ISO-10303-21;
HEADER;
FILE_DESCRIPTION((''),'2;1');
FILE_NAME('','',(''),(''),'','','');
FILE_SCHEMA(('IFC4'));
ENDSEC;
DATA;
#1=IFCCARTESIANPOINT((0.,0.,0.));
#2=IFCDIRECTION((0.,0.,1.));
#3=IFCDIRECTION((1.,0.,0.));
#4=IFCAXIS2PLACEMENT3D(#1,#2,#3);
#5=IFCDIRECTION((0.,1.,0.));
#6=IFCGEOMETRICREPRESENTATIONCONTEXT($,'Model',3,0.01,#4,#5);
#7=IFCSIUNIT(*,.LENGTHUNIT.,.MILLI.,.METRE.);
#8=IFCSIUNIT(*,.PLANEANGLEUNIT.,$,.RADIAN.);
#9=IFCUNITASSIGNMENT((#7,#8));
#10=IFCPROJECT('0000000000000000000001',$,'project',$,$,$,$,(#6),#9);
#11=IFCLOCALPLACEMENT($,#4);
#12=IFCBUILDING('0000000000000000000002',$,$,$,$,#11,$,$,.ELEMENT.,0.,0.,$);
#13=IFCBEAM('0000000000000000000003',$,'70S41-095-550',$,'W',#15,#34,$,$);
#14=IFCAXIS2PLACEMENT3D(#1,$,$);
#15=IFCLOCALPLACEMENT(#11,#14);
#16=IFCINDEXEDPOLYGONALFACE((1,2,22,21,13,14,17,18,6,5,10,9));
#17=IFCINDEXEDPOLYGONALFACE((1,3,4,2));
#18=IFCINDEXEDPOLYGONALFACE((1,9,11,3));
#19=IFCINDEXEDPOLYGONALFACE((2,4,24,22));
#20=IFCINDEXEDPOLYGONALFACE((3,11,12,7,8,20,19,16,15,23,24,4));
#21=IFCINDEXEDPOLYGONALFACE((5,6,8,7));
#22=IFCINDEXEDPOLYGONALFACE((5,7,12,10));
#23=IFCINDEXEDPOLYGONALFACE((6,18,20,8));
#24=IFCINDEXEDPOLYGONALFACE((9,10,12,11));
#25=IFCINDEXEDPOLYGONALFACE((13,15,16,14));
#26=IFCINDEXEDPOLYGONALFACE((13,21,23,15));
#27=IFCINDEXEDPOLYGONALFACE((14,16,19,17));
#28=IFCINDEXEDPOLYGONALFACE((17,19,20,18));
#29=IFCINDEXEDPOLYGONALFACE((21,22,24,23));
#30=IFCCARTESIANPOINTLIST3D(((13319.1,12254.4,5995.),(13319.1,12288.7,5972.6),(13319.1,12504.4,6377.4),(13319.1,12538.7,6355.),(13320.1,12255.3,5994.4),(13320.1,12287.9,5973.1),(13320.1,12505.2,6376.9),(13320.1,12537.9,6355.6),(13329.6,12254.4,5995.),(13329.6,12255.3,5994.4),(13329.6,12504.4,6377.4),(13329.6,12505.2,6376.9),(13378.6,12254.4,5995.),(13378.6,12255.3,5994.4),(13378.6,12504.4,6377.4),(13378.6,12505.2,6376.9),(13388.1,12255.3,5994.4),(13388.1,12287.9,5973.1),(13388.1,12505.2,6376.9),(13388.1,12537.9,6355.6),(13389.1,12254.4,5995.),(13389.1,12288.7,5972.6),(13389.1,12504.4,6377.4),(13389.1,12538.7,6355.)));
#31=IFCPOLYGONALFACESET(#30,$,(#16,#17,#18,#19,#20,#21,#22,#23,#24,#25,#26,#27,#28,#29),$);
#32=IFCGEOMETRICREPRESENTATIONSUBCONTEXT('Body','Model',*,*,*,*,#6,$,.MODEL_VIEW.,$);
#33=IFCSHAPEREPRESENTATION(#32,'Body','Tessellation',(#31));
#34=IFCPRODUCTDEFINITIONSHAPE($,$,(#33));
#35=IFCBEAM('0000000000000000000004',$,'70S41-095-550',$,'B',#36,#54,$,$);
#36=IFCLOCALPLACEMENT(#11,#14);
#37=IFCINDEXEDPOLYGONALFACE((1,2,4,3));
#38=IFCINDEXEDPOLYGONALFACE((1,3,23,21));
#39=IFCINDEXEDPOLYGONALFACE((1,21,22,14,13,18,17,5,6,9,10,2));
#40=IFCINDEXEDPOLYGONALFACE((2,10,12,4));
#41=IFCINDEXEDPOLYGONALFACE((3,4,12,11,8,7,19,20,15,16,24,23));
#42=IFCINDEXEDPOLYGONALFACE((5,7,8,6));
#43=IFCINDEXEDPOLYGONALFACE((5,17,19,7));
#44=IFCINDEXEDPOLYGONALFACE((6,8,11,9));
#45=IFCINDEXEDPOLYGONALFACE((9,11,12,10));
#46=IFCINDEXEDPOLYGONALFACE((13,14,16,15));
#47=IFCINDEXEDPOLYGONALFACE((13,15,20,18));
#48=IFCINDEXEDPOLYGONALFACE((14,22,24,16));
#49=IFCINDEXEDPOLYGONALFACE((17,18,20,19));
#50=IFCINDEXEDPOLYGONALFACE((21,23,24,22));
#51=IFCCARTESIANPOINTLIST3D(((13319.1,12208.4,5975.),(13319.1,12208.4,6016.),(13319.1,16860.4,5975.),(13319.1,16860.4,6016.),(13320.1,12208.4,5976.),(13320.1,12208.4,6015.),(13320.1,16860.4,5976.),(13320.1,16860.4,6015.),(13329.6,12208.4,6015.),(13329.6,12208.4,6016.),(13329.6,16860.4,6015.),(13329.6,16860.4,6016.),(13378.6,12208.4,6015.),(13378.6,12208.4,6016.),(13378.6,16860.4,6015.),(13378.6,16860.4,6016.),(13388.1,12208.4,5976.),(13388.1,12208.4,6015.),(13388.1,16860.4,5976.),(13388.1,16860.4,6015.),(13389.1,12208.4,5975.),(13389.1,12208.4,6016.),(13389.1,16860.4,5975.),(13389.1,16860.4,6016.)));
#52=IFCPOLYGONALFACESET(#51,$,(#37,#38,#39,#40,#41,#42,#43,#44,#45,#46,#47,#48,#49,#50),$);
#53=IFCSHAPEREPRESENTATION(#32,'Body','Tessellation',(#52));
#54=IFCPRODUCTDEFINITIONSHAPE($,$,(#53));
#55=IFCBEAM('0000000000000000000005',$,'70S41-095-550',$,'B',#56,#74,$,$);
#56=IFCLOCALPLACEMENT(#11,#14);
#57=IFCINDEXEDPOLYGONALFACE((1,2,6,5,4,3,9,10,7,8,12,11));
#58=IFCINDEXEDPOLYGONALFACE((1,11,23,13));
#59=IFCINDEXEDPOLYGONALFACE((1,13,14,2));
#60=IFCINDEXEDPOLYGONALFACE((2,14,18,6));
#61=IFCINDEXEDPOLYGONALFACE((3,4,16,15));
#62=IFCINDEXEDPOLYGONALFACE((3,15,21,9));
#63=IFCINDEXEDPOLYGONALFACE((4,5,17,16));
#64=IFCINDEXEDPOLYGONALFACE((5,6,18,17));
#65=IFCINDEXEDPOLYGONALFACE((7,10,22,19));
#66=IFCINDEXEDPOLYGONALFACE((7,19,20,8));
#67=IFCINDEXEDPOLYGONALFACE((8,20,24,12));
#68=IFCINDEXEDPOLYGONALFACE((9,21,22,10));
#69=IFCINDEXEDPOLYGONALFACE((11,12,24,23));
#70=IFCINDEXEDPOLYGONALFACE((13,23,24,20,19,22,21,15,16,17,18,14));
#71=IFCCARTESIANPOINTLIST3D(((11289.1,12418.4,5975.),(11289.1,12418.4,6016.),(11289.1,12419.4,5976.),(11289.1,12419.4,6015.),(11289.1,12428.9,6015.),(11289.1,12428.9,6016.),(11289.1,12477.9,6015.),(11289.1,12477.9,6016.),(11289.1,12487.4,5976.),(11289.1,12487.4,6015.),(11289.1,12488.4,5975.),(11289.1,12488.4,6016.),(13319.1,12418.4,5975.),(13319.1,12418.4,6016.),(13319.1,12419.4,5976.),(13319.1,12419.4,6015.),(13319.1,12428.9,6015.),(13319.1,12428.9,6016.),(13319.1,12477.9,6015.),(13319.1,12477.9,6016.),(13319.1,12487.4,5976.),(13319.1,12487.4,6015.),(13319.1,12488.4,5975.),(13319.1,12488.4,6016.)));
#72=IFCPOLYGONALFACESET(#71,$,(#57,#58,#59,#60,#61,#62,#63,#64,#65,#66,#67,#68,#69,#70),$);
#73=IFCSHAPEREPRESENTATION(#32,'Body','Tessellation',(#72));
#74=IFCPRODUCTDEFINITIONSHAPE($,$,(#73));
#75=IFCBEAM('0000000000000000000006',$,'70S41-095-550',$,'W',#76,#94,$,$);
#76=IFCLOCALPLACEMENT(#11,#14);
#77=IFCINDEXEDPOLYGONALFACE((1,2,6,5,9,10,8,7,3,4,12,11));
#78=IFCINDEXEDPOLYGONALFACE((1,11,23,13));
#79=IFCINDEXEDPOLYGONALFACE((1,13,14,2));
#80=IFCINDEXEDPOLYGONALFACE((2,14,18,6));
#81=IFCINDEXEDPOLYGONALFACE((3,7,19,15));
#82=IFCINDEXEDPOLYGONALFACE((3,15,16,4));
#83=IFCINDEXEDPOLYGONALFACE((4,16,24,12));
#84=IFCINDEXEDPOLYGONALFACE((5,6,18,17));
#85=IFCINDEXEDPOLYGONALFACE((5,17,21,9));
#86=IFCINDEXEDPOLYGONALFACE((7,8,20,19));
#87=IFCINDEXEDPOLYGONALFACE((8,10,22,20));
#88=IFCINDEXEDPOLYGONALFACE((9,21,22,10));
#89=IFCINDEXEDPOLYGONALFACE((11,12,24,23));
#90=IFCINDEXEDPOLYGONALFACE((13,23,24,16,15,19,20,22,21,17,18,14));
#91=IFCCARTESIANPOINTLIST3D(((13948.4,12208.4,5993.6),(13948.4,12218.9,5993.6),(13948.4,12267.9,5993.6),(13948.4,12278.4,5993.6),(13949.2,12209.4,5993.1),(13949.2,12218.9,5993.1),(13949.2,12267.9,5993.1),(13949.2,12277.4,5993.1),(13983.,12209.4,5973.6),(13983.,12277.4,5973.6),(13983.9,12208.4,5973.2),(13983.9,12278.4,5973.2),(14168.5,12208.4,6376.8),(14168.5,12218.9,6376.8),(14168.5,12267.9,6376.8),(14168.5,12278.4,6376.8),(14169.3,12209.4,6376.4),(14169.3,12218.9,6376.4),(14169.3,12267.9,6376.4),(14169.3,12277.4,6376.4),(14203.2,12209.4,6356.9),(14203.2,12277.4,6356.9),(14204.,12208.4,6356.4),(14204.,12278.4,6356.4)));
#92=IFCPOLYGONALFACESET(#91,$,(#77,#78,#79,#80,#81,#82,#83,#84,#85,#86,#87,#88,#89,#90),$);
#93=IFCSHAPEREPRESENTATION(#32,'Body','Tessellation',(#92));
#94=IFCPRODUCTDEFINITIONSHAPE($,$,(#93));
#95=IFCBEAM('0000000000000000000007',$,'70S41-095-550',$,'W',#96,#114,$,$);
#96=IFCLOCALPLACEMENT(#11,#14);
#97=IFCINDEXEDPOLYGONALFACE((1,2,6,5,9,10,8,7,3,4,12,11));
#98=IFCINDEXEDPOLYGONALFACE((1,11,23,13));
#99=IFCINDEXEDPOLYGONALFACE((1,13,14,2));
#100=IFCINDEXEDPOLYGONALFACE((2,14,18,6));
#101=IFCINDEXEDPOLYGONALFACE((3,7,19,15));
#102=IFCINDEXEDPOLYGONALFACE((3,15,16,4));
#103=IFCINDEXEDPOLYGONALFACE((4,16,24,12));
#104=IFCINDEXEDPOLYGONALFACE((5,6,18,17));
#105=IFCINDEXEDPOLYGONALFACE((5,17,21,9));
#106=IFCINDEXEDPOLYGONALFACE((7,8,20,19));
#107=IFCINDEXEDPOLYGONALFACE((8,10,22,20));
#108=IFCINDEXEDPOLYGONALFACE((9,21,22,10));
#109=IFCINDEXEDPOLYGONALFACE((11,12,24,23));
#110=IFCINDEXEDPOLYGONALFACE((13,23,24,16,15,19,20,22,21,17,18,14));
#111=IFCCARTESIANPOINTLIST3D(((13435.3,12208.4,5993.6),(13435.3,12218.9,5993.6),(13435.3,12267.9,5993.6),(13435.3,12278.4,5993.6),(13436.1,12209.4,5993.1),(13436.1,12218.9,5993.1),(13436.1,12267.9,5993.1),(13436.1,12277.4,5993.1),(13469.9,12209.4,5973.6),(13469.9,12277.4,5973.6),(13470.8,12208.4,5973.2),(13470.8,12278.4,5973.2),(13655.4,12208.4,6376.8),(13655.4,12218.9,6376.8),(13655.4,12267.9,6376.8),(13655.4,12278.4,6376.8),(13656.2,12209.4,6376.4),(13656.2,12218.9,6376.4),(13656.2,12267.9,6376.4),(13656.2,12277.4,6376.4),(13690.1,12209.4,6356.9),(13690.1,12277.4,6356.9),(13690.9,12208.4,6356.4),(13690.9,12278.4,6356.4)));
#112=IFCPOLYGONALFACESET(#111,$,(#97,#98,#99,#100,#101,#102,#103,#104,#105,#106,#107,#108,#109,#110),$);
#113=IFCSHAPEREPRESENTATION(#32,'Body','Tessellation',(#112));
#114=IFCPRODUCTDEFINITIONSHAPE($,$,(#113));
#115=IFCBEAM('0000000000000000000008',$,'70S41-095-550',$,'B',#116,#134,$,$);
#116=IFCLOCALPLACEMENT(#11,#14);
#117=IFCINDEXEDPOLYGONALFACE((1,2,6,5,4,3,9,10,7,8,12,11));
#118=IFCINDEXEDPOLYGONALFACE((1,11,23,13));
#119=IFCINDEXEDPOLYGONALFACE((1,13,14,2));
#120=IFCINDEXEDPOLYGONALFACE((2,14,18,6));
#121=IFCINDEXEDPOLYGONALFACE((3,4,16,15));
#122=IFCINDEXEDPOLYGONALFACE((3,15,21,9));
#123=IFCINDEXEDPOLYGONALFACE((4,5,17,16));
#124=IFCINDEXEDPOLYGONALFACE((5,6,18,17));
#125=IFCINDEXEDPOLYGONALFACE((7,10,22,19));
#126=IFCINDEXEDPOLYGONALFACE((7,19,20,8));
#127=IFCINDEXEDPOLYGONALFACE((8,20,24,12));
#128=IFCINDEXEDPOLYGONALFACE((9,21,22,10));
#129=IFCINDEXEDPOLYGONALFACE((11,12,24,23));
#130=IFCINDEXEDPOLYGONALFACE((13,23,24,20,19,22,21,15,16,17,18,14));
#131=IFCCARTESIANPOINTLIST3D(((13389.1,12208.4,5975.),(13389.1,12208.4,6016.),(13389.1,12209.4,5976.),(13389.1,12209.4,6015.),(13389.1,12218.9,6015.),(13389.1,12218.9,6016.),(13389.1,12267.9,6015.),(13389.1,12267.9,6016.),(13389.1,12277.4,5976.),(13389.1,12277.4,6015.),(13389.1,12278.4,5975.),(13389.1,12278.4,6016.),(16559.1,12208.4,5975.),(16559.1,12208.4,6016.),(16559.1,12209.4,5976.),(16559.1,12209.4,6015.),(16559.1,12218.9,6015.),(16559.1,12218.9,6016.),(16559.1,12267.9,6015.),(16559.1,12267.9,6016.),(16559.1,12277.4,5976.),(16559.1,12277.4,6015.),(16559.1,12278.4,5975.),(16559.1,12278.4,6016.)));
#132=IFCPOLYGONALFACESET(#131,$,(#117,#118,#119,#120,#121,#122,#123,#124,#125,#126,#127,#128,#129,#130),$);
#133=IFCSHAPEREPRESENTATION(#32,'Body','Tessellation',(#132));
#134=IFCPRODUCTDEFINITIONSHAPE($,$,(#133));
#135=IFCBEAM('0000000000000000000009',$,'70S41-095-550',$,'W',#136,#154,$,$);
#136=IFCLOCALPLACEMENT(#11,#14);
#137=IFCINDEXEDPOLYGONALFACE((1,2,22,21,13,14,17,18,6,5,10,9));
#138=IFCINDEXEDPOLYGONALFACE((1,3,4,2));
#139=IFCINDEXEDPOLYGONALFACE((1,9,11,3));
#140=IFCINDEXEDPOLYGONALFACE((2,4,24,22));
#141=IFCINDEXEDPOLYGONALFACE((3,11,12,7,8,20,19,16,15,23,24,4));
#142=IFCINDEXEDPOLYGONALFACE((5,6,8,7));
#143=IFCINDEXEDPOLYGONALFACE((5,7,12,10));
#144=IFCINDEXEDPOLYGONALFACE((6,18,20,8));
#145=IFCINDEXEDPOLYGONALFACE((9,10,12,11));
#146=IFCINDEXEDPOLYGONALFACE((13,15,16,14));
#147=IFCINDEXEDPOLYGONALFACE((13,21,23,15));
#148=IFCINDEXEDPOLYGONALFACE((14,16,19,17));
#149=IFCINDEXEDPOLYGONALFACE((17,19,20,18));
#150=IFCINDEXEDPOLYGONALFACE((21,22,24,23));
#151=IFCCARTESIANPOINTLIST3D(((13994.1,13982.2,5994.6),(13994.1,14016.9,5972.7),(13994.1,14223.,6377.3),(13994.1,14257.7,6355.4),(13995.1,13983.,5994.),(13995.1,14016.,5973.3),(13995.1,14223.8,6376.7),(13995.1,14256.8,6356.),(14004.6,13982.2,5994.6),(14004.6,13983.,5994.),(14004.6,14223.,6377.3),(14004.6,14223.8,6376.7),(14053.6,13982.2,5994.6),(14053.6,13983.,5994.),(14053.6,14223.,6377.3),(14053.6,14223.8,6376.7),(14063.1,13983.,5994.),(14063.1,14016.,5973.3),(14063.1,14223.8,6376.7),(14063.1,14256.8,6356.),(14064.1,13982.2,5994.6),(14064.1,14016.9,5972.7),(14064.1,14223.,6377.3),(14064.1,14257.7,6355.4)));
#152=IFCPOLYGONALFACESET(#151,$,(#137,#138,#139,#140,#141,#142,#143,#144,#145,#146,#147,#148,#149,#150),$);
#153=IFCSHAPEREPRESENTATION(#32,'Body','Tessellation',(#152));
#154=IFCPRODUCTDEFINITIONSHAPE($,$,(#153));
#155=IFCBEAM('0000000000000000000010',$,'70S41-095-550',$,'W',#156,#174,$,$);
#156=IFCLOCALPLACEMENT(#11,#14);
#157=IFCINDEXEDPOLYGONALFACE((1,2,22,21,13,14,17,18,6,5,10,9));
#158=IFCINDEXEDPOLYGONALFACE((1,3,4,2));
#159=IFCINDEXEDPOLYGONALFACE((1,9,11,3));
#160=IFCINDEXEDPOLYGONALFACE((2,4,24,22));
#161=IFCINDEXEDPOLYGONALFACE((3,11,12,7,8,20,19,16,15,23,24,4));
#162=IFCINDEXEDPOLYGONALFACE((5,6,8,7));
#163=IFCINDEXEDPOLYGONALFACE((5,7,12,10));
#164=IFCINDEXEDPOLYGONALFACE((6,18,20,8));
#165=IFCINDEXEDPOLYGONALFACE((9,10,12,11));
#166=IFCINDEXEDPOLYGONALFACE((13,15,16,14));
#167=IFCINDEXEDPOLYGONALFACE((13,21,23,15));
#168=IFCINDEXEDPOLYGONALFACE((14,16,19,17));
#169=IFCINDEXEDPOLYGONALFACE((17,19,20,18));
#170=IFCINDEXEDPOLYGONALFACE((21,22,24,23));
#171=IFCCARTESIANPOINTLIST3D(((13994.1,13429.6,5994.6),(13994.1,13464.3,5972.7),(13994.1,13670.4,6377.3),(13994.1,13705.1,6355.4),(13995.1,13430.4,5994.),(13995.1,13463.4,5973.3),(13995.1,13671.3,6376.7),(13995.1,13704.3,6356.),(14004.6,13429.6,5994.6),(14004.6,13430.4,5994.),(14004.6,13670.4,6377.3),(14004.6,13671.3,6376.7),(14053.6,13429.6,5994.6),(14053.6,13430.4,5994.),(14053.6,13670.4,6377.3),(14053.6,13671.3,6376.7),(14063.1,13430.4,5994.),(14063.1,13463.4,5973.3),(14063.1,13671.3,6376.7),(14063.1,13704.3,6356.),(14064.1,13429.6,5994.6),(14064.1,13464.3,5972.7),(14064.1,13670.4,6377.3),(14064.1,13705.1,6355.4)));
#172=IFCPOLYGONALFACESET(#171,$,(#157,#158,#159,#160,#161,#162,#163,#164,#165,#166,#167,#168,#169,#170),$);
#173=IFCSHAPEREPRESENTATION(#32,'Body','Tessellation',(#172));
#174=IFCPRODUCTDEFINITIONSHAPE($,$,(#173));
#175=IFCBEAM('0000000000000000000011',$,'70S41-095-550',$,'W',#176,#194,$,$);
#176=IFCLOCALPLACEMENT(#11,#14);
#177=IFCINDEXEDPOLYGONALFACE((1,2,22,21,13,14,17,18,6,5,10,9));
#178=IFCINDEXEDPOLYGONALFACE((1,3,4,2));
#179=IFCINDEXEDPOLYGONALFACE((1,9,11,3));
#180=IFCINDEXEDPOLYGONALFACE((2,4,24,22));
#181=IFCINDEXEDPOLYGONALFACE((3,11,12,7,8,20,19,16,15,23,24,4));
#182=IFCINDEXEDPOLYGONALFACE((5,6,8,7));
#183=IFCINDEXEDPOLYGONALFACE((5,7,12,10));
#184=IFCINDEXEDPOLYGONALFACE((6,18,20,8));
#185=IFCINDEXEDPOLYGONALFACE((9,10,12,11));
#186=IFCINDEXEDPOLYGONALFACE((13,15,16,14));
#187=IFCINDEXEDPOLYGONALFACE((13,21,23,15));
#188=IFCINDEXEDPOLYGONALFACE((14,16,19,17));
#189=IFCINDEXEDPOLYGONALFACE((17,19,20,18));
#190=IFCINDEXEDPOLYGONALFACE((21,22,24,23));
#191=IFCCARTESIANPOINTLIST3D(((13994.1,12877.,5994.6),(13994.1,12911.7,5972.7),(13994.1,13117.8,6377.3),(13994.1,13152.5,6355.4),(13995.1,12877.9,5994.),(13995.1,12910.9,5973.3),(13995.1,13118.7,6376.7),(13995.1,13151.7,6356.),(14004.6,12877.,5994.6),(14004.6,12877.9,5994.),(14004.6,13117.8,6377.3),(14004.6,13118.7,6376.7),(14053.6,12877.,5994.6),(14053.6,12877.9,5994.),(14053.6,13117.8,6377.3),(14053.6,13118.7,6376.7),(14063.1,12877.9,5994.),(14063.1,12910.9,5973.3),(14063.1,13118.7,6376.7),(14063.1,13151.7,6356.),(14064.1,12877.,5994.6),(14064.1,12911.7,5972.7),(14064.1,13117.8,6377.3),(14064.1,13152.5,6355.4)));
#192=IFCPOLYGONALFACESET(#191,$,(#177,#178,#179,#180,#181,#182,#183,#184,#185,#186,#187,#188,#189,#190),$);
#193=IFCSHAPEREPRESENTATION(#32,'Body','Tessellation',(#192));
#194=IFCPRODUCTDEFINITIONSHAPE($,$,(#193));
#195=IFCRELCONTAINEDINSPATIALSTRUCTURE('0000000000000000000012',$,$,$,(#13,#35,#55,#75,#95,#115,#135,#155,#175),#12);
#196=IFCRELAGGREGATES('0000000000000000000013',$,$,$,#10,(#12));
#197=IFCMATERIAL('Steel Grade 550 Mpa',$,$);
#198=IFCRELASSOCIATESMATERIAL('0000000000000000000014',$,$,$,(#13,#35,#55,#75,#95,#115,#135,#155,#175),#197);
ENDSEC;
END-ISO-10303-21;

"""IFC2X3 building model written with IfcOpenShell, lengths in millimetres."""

from ifc_helpers import new_model, si_unit, direction, frame, origin, origin_with_axes, origin_2d_with_axis, place, context, subcontext, project, spatial, c_section, extrude, source, transform, mapped, material, element, save


model = new_model("IFC2X3")

# Units and contexts
model_context = context("Model", 3, precision=0.01, world=origin_with_axes(), true_north=direction((0.0, 1.0, 0.0)))
body_context = subcontext(model_context, "Body", "Model", "MODEL_VIEW")
ifc_project = project(units=[si_unit("LENGTHUNIT", "METRE", prefix="MILLI"), si_unit("PLANEANGLEUNIT", "RADIAN")], contexts=[model_context])

# Building
building_placement = place(None, origin_with_axes())
building = spatial("IfcBuilding", under=ifc_project, at=building_placement, CompositionType="ELEMENT", ElevationOfRefHeight=0.0, ElevationOfTerrain=0.0)

# Beams
ifc_material = material(Name="Steel Grade 550 Mpa")
shared_shape_1 = source(origin(), body_context, "Body", "SweptSolid", [
    extrude(c_section(Depth=70.0, Width=41.0, WallThickness=1.0, Girth=10.5, at=origin_2d_with_axis()), origin_with_axes(), (0.0, 0.0, 1.0), 456.9),
])
beam_1_placement = place(None, frame((13354.1, 12271.6, 5983.8), z_axis=(0.0, 0.547116, 0.837057), x_axis=(0.0, -0.837057, 0.547116)))
element("IfcBeam", 1, at=beam_1_placement, inside=building, material=ifc_material, Name="70S41-095-550", ObjectType="W", context=body_context, shape_type="MappedRepresentation", body=[
    mapped(shared_shape_1, transform((0.0, 0.0, 0.0), scale=1.0)),
])
shared_shape_2 = source(origin(), body_context, "Body", "SweptSolid", [
    extrude(c_section(Depth=70.0, Width=41.0, WallThickness=1.0, Girth=10.5, at=origin_2d_with_axis()), origin_with_axes(), (0.0, 0.0, 1.0), 4652.0),
])
beam_2_placement = place(None, frame((13354.1, 12208.4, 5995.5), z_axis=(0.0, 1.0, 0.0), x_axis=(0.0, 0.0, 1.0)))
element("IfcBeam", 2, at=beam_2_placement, inside=building, material=ifc_material, Name="70S41-095-550", ObjectType="B", context=body_context, shape_type="MappedRepresentation", body=[
    mapped(shared_shape_2, transform((0.0, 0.0, 0.0), scale=1.0)),
])
shared_shape_3 = source(origin(), body_context, "Body", "SweptSolid", [
    extrude(c_section(Depth=70.0, Width=41.0, WallThickness=1.0, Girth=10.5, at=origin_2d_with_axis()), origin_with_axes(), (0.0, 0.0, 1.0), 2030.0),
])
beam_3_placement = place(None, frame((13319.1, 12453.4, 5995.5), z_axis=(-1.0, 0.0, 0.0), x_axis=(0.0, 0.0, 1.0)))
element("IfcBeam", 3, at=beam_3_placement, inside=building, material=ifc_material, Name="70S41-095-550", ObjectType="B", context=body_context, shape_type="MappedRepresentation", body=[
    mapped(shared_shape_3, transform((0.0, 0.0, 0.0), scale=1.0)),
])
shared_shape_4 = source(origin(), body_context, "Body", "SweptSolid", [
    extrude(c_section(Depth=70.0, Width=41.0, WallThickness=1.0, Girth=10.5, at=origin_2d_with_axis()), origin_with_axes(), (0.0, 0.0, 1.0), 442.0),
])
beam_4_placement = place(None, frame((13966.1, 12243.4, 5983.4), z_axis=(0.497993, 0.0, 0.867181), x_axis=(-0.867181, 0.0, 0.497993)))
element("IfcBeam", 4, at=beam_4_placement, inside=building, material=ifc_material, Name="70S41-095-550", ObjectType="W", context=body_context, shape_type="MappedRepresentation", body=[
    mapped(shared_shape_4, transform((0.0, 0.0, 0.0), scale=1.0)),
])
shared_shape_5 = source(origin(), body_context, "Body", "SweptSolid", [
    extrude(c_section(Depth=70.0, Width=41.0, WallThickness=1.0, Girth=10.5, at=origin_2d_with_axis()), origin_with_axes(), (0.0, 0.0, 1.0), 442.0),
])
beam_5_placement = place(None, frame((13453.0, 12243.4, 5983.4), z_axis=(0.497993, 0.0, 0.867181), x_axis=(-0.867181, 0.0, 0.497993)))
element("IfcBeam", 5, at=beam_5_placement, inside=building, material=ifc_material, Name="70S41-095-550", ObjectType="W", context=body_context, shape_type="MappedRepresentation", body=[
    mapped(shared_shape_5, transform((0.0, 0.0, 0.0), scale=1.0)),
])
shared_shape_6 = source(origin(), body_context, "Body", "SweptSolid", [
    extrude(c_section(Depth=70.0, Width=41.0, WallThickness=1.0, Girth=10.5, at=origin_2d_with_axis()), origin_with_axes(), (0.0, 0.0, 1.0), 3170.0),
])
beam_6_placement = place(None, frame((13389.1, 12243.4, 5995.5), z_axis=(1.0, 0.0, 0.0), x_axis=(0.0, 0.0, 1.0)))
element("IfcBeam", 6, at=beam_6_placement, inside=building, material=ifc_material, Name="70S41-095-550", ObjectType="B", context=body_context, shape_type="MappedRepresentation", body=[
    mapped(shared_shape_6, transform((0.0, 0.0, 0.0), scale=1.0)),
])
shared_shape_7 = source(origin(), body_context, "Body", "SweptSolid", [
    extrude(c_section(Depth=70.0, Width=41.0, WallThickness=1.0, Girth=10.5, at=origin_2d_with_axis()), origin_with_axes(), (0.0, 0.0, 1.0), 452.2),
])
beam_7_placement = place(None, frame((14029.1, 13999.5, 5983.7), z_axis=(0.0, 0.532581, 0.846379), x_axis=(0.0, -0.846379, 0.532581)))
element("IfcBeam", 7, at=beam_7_placement, inside=building, material=ifc_material, Name="70S41-095-550", ObjectType="W", context=body_context, shape_type="MappedRepresentation", body=[
    mapped(shared_shape_7, transform((0.0, 0.0, 0.0), scale=1.0)),
])
shared_shape_8 = source(origin(), body_context, "Body", "SweptSolid", [
    extrude(c_section(Depth=70.0, Width=41.0, WallThickness=1.0, Girth=10.5, at=origin_2d_with_axis()), origin_with_axes(), (0.0, 0.0, 1.0), 452.2),
])
beam_8_placement = place(None, frame((14029.1, 13446.9, 5983.7), z_axis=(0.0, 0.532581, 0.846379), x_axis=(0.0, -0.846379, 0.532581)))
element("IfcBeam", 8, at=beam_8_placement, inside=building, material=ifc_material, Name="70S41-095-550", ObjectType="W", context=body_context, shape_type="MappedRepresentation", body=[
    mapped(shared_shape_8, transform((0.0, 0.0, 0.0), scale=1.0)),
])
shared_shape_9 = source(origin(), body_context, "Body", "SweptSolid", [
    extrude(c_section(Depth=70.0, Width=41.0, WallThickness=1.0, Girth=10.5, at=origin_2d_with_axis()), origin_with_axes(), (0.0, 0.0, 1.0), 452.2),
])
beam_9_placement = place(None, frame((14029.1, 12894.4, 5983.7), z_axis=(0.0, 0.532581, 0.846379), x_axis=(0.0, -0.846379, 0.532581)))
element("IfcBeam", 9, at=beam_9_placement, inside=building, material=ifc_material, Name="70S41-095-550", ObjectType="W", context=body_context, shape_type="MappedRepresentation", body=[
    mapped(shared_shape_9, transform((0.0, 0.0, 0.0), scale=1.0)),
])

save(model, "model.ifc")
